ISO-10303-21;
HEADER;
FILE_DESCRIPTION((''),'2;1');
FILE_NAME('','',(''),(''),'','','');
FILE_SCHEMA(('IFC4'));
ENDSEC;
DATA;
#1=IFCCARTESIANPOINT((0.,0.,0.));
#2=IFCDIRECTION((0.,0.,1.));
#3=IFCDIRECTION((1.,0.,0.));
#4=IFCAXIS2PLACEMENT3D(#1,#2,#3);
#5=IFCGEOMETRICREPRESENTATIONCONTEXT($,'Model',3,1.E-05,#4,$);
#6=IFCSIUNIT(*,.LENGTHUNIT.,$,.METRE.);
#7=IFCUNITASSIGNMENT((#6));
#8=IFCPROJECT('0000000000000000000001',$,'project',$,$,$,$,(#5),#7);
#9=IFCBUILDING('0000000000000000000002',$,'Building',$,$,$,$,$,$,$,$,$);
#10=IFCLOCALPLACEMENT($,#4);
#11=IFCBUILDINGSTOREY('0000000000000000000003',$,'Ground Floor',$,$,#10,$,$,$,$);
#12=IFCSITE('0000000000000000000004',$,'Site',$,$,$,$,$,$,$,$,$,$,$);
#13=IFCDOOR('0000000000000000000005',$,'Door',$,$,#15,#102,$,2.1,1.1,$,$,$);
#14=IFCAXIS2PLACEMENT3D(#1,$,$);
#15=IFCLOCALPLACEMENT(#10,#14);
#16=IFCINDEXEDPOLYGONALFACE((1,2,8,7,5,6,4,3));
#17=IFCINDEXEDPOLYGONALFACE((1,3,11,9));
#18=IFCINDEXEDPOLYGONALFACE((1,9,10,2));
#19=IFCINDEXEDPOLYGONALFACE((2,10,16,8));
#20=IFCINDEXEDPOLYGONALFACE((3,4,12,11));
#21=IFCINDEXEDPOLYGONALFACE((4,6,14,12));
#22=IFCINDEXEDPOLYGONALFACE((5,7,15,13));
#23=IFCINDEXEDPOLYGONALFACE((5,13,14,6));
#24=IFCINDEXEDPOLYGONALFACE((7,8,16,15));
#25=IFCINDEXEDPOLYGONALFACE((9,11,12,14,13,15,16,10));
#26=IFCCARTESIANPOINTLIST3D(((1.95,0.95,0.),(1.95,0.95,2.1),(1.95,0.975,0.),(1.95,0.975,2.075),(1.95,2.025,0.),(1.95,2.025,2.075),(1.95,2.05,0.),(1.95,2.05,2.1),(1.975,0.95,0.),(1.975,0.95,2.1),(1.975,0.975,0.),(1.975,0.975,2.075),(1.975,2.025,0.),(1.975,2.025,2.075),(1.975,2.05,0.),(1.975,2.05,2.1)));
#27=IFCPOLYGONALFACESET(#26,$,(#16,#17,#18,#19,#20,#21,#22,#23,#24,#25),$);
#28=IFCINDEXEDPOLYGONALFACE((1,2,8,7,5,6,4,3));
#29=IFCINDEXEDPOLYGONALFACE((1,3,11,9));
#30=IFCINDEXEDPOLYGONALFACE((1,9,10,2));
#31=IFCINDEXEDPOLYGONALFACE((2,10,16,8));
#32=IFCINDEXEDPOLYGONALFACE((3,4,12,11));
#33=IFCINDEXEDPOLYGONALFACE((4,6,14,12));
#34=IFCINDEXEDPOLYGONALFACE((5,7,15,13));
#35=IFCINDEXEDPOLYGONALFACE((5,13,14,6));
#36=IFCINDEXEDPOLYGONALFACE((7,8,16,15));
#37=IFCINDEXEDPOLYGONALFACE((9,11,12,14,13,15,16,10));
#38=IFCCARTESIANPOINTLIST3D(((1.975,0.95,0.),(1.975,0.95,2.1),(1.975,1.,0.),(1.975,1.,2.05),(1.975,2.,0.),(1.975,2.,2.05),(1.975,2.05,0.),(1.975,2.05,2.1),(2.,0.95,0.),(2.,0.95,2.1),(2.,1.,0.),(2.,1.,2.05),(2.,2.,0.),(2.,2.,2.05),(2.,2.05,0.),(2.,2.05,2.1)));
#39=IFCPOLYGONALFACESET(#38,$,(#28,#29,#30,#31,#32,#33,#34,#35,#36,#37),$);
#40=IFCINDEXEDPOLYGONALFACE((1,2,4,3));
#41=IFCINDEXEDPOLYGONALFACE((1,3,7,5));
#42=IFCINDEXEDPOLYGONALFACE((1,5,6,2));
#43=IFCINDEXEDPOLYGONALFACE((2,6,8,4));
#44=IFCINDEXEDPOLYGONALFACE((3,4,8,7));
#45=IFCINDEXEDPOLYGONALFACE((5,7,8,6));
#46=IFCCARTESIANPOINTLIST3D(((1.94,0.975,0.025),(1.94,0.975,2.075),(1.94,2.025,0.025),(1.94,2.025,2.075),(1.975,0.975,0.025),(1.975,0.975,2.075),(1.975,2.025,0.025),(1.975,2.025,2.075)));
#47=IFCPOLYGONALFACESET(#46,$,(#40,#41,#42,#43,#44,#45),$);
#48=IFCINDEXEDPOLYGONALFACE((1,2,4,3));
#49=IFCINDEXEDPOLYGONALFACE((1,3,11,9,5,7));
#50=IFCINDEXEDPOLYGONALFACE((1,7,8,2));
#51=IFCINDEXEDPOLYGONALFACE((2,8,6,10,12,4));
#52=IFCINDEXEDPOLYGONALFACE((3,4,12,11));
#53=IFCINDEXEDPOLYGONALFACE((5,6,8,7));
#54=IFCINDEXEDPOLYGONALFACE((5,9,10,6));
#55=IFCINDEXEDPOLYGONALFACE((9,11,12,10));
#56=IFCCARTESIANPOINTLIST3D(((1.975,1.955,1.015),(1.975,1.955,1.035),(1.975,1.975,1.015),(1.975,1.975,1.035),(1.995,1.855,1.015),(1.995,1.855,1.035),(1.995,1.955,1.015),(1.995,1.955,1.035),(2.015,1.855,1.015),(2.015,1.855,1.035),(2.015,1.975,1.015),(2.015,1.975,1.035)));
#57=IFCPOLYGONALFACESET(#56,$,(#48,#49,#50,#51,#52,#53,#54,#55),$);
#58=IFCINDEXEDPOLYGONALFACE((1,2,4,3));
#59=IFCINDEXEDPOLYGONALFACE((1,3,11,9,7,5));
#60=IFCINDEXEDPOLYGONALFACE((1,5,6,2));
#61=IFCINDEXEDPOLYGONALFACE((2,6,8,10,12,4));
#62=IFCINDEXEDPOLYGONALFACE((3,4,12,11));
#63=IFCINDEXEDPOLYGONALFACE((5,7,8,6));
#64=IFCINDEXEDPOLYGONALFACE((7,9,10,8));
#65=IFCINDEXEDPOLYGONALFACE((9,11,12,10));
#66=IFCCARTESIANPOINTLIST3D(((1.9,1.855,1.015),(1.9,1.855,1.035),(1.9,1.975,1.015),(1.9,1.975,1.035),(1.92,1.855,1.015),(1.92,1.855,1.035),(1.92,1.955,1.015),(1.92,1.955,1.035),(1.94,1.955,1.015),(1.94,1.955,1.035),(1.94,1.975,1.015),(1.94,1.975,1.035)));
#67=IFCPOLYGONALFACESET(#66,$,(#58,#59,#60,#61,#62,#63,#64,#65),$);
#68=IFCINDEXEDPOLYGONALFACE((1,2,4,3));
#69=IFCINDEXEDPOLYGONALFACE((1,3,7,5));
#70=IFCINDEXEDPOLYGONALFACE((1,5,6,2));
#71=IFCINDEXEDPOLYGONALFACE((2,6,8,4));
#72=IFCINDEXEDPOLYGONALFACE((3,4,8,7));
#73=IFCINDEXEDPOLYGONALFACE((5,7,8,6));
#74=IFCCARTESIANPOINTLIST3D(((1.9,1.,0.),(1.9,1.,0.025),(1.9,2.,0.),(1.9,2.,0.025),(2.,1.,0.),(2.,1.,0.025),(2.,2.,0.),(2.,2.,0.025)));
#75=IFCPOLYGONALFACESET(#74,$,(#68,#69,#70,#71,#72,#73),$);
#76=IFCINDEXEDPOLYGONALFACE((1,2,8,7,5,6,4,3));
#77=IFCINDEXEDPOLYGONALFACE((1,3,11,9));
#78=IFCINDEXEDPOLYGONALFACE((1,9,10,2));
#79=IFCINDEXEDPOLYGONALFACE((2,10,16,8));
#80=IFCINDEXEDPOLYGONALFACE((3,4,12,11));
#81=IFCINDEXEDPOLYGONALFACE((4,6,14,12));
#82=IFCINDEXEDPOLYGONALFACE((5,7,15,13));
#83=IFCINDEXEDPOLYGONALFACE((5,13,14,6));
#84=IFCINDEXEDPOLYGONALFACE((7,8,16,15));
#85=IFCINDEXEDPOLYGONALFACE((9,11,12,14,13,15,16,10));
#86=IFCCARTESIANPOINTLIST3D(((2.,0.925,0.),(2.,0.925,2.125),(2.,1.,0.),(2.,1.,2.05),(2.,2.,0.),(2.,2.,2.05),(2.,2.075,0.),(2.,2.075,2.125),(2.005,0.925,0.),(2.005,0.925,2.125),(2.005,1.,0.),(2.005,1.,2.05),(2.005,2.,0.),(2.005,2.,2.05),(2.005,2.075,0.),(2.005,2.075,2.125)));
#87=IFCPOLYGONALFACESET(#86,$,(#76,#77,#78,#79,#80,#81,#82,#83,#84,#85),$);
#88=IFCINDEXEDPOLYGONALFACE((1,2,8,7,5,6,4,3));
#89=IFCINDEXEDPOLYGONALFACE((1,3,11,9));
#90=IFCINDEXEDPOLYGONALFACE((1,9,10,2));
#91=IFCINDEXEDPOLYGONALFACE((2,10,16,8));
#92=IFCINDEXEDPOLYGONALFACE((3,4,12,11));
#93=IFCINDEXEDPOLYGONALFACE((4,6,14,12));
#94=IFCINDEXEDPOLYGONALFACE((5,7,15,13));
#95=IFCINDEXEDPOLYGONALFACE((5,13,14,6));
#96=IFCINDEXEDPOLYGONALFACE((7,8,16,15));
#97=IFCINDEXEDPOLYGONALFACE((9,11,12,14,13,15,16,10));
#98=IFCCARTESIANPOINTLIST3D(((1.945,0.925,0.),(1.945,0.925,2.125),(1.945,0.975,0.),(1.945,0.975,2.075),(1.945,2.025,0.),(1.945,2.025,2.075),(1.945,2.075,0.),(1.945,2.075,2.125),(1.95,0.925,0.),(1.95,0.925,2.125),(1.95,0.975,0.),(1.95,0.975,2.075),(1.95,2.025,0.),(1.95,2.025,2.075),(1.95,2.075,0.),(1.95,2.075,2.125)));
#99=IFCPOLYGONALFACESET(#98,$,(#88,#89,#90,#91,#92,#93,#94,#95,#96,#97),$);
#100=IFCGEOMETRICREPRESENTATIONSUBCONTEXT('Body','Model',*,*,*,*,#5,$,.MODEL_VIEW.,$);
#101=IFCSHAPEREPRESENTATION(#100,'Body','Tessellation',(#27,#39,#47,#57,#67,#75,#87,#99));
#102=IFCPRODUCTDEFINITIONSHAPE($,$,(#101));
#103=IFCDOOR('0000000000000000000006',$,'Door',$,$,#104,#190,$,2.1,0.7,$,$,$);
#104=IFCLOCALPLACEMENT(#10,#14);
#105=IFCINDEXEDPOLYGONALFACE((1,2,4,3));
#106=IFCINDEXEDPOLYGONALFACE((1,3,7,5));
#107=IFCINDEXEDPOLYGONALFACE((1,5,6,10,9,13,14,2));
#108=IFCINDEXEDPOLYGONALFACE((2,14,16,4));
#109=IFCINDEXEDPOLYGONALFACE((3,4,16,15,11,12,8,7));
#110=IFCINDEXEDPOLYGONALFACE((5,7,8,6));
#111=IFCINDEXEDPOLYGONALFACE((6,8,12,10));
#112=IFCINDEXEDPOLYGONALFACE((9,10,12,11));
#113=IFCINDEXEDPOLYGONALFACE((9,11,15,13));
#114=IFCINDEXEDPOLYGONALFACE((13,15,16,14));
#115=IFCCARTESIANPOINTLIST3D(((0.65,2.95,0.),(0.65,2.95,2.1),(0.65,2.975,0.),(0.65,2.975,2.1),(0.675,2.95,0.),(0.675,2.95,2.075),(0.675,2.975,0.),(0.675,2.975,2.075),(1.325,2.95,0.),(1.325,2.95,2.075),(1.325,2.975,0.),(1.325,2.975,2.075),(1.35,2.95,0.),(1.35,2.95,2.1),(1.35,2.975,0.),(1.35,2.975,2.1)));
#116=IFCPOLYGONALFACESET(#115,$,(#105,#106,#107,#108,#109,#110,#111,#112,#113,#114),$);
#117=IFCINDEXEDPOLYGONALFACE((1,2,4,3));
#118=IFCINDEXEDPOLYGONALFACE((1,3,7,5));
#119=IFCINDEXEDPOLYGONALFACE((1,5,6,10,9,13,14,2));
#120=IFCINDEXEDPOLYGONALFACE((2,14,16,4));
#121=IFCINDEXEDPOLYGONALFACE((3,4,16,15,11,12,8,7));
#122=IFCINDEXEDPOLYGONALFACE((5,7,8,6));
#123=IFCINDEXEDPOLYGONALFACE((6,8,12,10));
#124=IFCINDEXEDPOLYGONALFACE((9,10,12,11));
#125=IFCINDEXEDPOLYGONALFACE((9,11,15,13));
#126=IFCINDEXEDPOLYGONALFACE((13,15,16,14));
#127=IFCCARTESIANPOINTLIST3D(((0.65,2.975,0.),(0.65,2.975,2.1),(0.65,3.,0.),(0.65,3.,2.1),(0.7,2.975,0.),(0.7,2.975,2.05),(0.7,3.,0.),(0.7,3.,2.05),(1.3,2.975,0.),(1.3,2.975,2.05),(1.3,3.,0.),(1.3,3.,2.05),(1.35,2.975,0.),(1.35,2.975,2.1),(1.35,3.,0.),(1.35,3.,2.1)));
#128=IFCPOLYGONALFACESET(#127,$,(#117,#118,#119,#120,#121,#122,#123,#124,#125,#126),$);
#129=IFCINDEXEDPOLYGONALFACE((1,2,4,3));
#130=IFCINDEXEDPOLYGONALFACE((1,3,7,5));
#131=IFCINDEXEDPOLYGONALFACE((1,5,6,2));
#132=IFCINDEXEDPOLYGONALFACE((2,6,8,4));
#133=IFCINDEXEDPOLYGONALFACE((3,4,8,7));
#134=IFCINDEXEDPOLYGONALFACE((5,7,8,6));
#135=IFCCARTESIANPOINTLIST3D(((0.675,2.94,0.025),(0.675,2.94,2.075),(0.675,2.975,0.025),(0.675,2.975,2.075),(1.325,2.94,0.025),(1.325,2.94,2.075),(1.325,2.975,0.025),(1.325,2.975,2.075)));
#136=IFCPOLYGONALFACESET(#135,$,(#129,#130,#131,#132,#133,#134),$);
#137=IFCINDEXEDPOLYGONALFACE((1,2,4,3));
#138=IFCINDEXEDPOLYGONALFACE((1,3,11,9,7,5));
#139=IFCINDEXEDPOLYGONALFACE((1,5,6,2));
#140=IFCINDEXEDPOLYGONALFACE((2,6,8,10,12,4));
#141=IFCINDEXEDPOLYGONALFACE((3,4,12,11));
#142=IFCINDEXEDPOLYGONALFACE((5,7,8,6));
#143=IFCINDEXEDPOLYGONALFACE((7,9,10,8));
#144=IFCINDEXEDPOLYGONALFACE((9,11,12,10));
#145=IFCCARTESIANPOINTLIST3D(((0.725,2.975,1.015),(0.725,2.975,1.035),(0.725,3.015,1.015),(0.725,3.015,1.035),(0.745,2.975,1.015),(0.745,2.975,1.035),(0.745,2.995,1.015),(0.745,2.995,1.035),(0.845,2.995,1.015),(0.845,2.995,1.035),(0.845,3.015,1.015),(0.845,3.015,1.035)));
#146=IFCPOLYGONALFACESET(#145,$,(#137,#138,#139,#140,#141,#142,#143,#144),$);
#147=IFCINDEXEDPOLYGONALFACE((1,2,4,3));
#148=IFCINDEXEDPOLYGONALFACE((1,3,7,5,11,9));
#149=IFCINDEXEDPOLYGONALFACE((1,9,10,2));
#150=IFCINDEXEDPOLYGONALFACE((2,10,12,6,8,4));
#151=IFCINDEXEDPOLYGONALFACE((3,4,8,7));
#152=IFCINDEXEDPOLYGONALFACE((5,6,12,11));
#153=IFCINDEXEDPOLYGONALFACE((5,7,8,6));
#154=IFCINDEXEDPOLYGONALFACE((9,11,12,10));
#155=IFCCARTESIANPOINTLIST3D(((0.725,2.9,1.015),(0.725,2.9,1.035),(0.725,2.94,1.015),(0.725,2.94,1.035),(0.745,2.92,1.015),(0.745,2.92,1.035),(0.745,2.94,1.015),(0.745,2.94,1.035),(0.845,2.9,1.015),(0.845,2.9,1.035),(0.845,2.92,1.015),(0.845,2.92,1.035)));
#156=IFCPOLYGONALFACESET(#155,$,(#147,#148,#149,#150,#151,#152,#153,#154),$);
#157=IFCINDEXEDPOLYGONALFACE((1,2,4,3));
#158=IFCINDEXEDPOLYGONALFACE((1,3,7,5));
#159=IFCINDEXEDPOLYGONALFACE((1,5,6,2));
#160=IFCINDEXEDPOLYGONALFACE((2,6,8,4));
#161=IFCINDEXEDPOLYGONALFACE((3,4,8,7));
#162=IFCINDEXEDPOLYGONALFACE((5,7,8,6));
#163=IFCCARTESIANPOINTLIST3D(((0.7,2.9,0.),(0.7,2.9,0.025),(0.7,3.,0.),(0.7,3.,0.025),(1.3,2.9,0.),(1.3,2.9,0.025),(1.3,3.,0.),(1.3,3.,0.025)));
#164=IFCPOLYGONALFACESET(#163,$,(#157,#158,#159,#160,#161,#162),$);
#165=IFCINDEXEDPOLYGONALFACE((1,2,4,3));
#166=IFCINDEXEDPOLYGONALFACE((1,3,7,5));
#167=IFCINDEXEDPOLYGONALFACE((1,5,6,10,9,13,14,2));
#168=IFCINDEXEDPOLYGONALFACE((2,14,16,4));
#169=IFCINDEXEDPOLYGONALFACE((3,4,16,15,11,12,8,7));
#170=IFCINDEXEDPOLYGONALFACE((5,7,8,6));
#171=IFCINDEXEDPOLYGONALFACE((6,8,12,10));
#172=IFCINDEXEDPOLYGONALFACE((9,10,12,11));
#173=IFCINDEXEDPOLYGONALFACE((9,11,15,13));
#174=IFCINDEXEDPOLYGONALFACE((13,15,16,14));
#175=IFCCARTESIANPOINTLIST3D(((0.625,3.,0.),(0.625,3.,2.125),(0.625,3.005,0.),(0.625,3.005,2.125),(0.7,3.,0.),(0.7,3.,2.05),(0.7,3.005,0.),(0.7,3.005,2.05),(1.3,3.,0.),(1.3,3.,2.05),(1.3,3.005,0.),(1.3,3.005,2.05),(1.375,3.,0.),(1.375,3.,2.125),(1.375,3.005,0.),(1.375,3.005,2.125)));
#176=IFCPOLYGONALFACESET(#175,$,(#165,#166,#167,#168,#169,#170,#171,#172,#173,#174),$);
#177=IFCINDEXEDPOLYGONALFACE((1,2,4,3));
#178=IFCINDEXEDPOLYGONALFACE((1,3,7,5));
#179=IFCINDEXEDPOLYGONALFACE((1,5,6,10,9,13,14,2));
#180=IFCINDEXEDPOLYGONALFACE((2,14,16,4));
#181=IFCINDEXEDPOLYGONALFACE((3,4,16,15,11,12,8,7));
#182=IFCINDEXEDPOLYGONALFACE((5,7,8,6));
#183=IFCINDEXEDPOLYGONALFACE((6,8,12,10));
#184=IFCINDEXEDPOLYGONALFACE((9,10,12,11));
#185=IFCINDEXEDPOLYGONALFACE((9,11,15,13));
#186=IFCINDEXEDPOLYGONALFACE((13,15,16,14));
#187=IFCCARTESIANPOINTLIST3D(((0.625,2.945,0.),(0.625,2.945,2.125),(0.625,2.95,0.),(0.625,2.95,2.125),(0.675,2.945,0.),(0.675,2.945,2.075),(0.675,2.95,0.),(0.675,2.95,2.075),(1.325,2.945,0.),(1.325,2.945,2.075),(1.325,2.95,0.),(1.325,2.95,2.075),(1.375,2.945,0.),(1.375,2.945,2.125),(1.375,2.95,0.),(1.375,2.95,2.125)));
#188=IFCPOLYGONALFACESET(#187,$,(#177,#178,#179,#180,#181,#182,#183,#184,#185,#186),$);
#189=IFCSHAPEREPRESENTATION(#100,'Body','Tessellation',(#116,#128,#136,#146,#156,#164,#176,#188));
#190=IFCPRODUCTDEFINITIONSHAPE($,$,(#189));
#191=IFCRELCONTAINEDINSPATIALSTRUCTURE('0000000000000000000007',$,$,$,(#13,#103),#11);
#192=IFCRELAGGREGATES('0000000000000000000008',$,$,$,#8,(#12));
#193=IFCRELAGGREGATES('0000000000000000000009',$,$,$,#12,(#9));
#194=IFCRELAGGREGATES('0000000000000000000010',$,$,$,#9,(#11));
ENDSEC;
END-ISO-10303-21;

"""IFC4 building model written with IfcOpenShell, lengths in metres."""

from ifc_helpers import new_model, si_unit, frame, origin_with_axes, place, context, subcontext, project, spatial, line, indexed_curve, outline, extrude, element, save


model = new_model("IFC4")

# Units and contexts
model_context = context("Model", 3, precision=1e-05, world=origin_with_axes())
body_context = subcontext(model_context, "Body", "Model", "MODEL_VIEW")
ifc_project = project(units=[si_unit("LENGTHUNIT", "METRE")], contexts=[model_context])

# Site, building, storey
site = spatial("IfcSite", under=ifc_project, Name="Site")
building = spatial("IfcBuilding", under=site, Name="Building")
storey_placement = place(None, origin_with_axes())
storey = spatial("IfcBuildingStorey", under=building, at=storey_placement, Name="Ground Floor")

# Doors
door_1_placement = place(storey_placement, frame((2.0, 0.95, 0.0), z_axis=(0.0, 0.0, 1.0), x_axis=(0.0, 1.0, 0.0)))
element("IfcDoor", 1, at=door_1_placement, inside=storey, Name="Door", OverallHeight=2.1, OverallWidth=1.1, context=body_context, shape_type="SweptSolid", body=[
    extrude(outline(indexed_curve([(0.0, 0.0), (0.0, 2.1), (1.1, 2.1), (1.1, 0.0), (1.075, 0.0), (1.075, 2.075), (0.025, 2.075), (0.025, 0.0)], segments=[line(1, 2, 3, 4, 5, 6, 7, 8, 1)])), frame((0.0, 0.025, 0.0), z_axis=(0.0, -1.0, 0.0), x_axis=(1.0, 0.0, 0.0)), (0.0, 0.0, -1.0), 0.025),
    extrude(outline(indexed_curve([(0.0, 0.0), (0.0, 2.1), (1.1, 2.1), (1.1, 0.0), (1.05, 0.0), (1.05, 2.05), (0.05, 2.05), (0.05, 0.0)], segments=[line(1, 2, 3, 4, 5, 6, 7, 8, 1)])), frame((0.0, 0.0, 0.0), z_axis=(0.0, -1.0, 0.0), x_axis=(1.0, 0.0, 0.0)), (0.0, 0.0, -1.0), 0.025),
    extrude(outline(indexed_curve([(0.0, 0.0), (1.05, 0.0), (1.05, 0.035), (0.0, 0.035)], segments=[line(1, 2, 3, 4, 1)])), frame((0.025, 0.025, 0.025), z_axis=(0.0, 0.0, 1.0), x_axis=(1.0, 0.0, 0.0)), (0.0, 0.0, 1.0), 2.05),
    extrude(outline(indexed_curve([(0.0, 0.0), (0.0, -0.04), (-0.12, -0.04), (-0.12, -0.02), (-0.02, -0.02), (-0.02, 0.0)], segments=[line(1, 2, 3, 4, 5, 6, 1)])), frame((1.025, 0.025, 1.015), z_axis=(0.0, 0.0, 1.0), x_axis=(1.0, 0.0, 0.0)), (0.0, 0.0, 1.0), 0.02),
    extrude(outline(indexed_curve([(0.0, 0.0), (0.0, 0.04), (-0.12, 0.04), (-0.12, 0.02), (-0.02, 0.02), (-0.02, 0.0)], segments=[line(1, 2, 3, 4, 5, 6, 1)])), frame((1.025, 0.06, 1.015), z_axis=(0.0, 0.0, 1.0), x_axis=(1.0, 0.0, 0.0)), (0.0, 0.0, 1.0), 0.02),
    extrude(outline(indexed_curve([(0.0, 0.0), (1.0, 0.0), (1.0, 0.1), (0.0, 0.1)], segments=[line(1, 2, 3, 4, 1)])), frame((0.05, 0.0, 0.0), z_axis=(0.0, 0.0, 1.0), x_axis=(1.0, 0.0, 0.0)), (0.0, 0.0, 1.0), 0.025),
    extrude(outline(indexed_curve([(0.0, 0.0), (0.0, 2.125), (1.15, 2.125), (1.15, 0.0), (1.075, 0.0), (1.075, 2.05), (0.075, 2.05), (0.075, 0.0)], segments=[line(1, 2, 3, 4, 5, 6, 7, 8, 1)])), frame((-0.025, -0.005, 0.0), z_axis=(0.0, -1.0, 0.0), x_axis=(1.0, 0.0, 0.0)), (0.0, 0.0, -1.0), 0.005),
    extrude(outline(indexed_curve([(0.0, 0.0), (0.0, 2.125), (1.15, 2.125), (1.15, 0.0), (1.1, 0.0), (1.1, 2.075), (0.05, 2.075), (0.05, 0.0)], segments=[line(1, 2, 3, 4, 5, 6, 7, 8, 1)])), frame((-0.025, 0.05, 0.0), z_axis=(0.0, -1.0, 0.0), x_axis=(1.0, 0.0, 0.0)), (0.0, 0.0, -1.0), 0.005),
])
door_2_placement = place(storey_placement, frame((1.35, 3.0, 0.0), z_axis=(0.0, 0.0, 1.0), x_axis=(-1.0, 0.0, 0.0)))
element("IfcDoor", 2, at=door_2_placement, inside=storey, Name="Door", OverallHeight=2.1, OverallWidth=0.7, context=body_context, shape_type="SweptSolid", body=[
    extrude(outline(indexed_curve([(0.0, 0.0), (0.0, 2.1), (0.7, 2.1), (0.7, 0.0), (0.675, 0.0), (0.675, 2.075), (0.025, 2.075), (0.025, 0.0)], segments=[line(1, 2, 3, 4, 5, 6, 7, 8, 1)])), frame((0.0, 0.025, 0.0), z_axis=(0.0, -1.0, 0.0), x_axis=(1.0, 0.0, 0.0)), (0.0, 0.0, -1.0), 0.025),
    extrude(outline(indexed_curve([(0.0, 0.0), (0.0, 2.1), (0.7, 2.1), (0.7, 0.0), (0.65, 0.0), (0.65, 2.05), (0.05, 2.05), (0.05, 0.0)], segments=[line(1, 2, 3, 4, 5, 6, 7, 8, 1)])), frame((0.0, 0.0, 0.0), z_axis=(0.0, -1.0, 0.0), x_axis=(1.0, 0.0, 0.0)), (0.0, 0.0, -1.0), 0.025),
    extrude(outline(indexed_curve([(0.0, 0.0), (0.65, 0.0), (0.65, 0.035), (0.0, 0.035)], segments=[line(1, 2, 3, 4, 1)])), frame((0.025, 0.025, 0.025), z_axis=(0.0, 0.0, 1.0), x_axis=(1.0, 0.0, 0.0)), (0.0, 0.0, 1.0), 2.05),
    extrude(outline(indexed_curve([(0.0, 0.0), (0.0, -0.04), (-0.12, -0.04), (-0.12, -0.02), (-0.02, -0.02), (-0.02, 0.0)], segments=[line(1, 2, 3, 4, 5, 6, 1)])), frame((0.625, 0.025, 1.015), z_axis=(0.0, 0.0, 1.0), x_axis=(1.0, 0.0, 0.0)), (0.0, 0.0, 1.0), 0.02),
    extrude(outline(indexed_curve([(0.0, 0.0), (0.0, 0.04), (-0.12, 0.04), (-0.12, 0.02), (-0.02, 0.02), (-0.02, 0.0)], segments=[line(1, 2, 3, 4, 5, 6, 1)])), frame((0.625, 0.06, 1.015), z_axis=(0.0, 0.0, 1.0), x_axis=(1.0, 0.0, 0.0)), (0.0, 0.0, 1.0), 0.02),
    extrude(outline(indexed_curve([(0.0, 0.0), (0.6, 0.0), (0.6, 0.1), (0.0, 0.1)], segments=[line(1, 2, 3, 4, 1)])), frame((0.05, 0.0, 0.0), z_axis=(0.0, 0.0, 1.0), x_axis=(1.0, 0.0, 0.0)), (0.0, 0.0, 1.0), 0.025),
    extrude(outline(indexed_curve([(0.0, 0.0), (0.0, 2.125), (0.75, 2.125), (0.75, 0.0), (0.675, 0.0), (0.675, 2.05), (0.075, 2.05), (0.075, 0.0)], segments=[line(1, 2, 3, 4, 5, 6, 7, 8, 1)])), frame((-0.025, -0.005, 0.0), z_axis=(0.0, -1.0, 0.0), x_axis=(1.0, 0.0, 0.0)), (0.0, 0.0, -1.0), 0.005),
    extrude(outline(indexed_curve([(0.0, 0.0), (0.0, 2.125), (0.75, 2.125), (0.75, 0.0), (0.7, 0.0), (0.7, 2.075), (0.05, 2.075), (0.05, 0.0)], segments=[line(1, 2, 3, 4, 5, 6, 7, 8, 1)])), frame((-0.025, 0.05, 0.0), z_axis=(0.0, -1.0, 0.0), x_axis=(1.0, 0.0, 0.0)), (0.0, 0.0, -1.0), 0.005),
])

save(model, "model.ifc")
